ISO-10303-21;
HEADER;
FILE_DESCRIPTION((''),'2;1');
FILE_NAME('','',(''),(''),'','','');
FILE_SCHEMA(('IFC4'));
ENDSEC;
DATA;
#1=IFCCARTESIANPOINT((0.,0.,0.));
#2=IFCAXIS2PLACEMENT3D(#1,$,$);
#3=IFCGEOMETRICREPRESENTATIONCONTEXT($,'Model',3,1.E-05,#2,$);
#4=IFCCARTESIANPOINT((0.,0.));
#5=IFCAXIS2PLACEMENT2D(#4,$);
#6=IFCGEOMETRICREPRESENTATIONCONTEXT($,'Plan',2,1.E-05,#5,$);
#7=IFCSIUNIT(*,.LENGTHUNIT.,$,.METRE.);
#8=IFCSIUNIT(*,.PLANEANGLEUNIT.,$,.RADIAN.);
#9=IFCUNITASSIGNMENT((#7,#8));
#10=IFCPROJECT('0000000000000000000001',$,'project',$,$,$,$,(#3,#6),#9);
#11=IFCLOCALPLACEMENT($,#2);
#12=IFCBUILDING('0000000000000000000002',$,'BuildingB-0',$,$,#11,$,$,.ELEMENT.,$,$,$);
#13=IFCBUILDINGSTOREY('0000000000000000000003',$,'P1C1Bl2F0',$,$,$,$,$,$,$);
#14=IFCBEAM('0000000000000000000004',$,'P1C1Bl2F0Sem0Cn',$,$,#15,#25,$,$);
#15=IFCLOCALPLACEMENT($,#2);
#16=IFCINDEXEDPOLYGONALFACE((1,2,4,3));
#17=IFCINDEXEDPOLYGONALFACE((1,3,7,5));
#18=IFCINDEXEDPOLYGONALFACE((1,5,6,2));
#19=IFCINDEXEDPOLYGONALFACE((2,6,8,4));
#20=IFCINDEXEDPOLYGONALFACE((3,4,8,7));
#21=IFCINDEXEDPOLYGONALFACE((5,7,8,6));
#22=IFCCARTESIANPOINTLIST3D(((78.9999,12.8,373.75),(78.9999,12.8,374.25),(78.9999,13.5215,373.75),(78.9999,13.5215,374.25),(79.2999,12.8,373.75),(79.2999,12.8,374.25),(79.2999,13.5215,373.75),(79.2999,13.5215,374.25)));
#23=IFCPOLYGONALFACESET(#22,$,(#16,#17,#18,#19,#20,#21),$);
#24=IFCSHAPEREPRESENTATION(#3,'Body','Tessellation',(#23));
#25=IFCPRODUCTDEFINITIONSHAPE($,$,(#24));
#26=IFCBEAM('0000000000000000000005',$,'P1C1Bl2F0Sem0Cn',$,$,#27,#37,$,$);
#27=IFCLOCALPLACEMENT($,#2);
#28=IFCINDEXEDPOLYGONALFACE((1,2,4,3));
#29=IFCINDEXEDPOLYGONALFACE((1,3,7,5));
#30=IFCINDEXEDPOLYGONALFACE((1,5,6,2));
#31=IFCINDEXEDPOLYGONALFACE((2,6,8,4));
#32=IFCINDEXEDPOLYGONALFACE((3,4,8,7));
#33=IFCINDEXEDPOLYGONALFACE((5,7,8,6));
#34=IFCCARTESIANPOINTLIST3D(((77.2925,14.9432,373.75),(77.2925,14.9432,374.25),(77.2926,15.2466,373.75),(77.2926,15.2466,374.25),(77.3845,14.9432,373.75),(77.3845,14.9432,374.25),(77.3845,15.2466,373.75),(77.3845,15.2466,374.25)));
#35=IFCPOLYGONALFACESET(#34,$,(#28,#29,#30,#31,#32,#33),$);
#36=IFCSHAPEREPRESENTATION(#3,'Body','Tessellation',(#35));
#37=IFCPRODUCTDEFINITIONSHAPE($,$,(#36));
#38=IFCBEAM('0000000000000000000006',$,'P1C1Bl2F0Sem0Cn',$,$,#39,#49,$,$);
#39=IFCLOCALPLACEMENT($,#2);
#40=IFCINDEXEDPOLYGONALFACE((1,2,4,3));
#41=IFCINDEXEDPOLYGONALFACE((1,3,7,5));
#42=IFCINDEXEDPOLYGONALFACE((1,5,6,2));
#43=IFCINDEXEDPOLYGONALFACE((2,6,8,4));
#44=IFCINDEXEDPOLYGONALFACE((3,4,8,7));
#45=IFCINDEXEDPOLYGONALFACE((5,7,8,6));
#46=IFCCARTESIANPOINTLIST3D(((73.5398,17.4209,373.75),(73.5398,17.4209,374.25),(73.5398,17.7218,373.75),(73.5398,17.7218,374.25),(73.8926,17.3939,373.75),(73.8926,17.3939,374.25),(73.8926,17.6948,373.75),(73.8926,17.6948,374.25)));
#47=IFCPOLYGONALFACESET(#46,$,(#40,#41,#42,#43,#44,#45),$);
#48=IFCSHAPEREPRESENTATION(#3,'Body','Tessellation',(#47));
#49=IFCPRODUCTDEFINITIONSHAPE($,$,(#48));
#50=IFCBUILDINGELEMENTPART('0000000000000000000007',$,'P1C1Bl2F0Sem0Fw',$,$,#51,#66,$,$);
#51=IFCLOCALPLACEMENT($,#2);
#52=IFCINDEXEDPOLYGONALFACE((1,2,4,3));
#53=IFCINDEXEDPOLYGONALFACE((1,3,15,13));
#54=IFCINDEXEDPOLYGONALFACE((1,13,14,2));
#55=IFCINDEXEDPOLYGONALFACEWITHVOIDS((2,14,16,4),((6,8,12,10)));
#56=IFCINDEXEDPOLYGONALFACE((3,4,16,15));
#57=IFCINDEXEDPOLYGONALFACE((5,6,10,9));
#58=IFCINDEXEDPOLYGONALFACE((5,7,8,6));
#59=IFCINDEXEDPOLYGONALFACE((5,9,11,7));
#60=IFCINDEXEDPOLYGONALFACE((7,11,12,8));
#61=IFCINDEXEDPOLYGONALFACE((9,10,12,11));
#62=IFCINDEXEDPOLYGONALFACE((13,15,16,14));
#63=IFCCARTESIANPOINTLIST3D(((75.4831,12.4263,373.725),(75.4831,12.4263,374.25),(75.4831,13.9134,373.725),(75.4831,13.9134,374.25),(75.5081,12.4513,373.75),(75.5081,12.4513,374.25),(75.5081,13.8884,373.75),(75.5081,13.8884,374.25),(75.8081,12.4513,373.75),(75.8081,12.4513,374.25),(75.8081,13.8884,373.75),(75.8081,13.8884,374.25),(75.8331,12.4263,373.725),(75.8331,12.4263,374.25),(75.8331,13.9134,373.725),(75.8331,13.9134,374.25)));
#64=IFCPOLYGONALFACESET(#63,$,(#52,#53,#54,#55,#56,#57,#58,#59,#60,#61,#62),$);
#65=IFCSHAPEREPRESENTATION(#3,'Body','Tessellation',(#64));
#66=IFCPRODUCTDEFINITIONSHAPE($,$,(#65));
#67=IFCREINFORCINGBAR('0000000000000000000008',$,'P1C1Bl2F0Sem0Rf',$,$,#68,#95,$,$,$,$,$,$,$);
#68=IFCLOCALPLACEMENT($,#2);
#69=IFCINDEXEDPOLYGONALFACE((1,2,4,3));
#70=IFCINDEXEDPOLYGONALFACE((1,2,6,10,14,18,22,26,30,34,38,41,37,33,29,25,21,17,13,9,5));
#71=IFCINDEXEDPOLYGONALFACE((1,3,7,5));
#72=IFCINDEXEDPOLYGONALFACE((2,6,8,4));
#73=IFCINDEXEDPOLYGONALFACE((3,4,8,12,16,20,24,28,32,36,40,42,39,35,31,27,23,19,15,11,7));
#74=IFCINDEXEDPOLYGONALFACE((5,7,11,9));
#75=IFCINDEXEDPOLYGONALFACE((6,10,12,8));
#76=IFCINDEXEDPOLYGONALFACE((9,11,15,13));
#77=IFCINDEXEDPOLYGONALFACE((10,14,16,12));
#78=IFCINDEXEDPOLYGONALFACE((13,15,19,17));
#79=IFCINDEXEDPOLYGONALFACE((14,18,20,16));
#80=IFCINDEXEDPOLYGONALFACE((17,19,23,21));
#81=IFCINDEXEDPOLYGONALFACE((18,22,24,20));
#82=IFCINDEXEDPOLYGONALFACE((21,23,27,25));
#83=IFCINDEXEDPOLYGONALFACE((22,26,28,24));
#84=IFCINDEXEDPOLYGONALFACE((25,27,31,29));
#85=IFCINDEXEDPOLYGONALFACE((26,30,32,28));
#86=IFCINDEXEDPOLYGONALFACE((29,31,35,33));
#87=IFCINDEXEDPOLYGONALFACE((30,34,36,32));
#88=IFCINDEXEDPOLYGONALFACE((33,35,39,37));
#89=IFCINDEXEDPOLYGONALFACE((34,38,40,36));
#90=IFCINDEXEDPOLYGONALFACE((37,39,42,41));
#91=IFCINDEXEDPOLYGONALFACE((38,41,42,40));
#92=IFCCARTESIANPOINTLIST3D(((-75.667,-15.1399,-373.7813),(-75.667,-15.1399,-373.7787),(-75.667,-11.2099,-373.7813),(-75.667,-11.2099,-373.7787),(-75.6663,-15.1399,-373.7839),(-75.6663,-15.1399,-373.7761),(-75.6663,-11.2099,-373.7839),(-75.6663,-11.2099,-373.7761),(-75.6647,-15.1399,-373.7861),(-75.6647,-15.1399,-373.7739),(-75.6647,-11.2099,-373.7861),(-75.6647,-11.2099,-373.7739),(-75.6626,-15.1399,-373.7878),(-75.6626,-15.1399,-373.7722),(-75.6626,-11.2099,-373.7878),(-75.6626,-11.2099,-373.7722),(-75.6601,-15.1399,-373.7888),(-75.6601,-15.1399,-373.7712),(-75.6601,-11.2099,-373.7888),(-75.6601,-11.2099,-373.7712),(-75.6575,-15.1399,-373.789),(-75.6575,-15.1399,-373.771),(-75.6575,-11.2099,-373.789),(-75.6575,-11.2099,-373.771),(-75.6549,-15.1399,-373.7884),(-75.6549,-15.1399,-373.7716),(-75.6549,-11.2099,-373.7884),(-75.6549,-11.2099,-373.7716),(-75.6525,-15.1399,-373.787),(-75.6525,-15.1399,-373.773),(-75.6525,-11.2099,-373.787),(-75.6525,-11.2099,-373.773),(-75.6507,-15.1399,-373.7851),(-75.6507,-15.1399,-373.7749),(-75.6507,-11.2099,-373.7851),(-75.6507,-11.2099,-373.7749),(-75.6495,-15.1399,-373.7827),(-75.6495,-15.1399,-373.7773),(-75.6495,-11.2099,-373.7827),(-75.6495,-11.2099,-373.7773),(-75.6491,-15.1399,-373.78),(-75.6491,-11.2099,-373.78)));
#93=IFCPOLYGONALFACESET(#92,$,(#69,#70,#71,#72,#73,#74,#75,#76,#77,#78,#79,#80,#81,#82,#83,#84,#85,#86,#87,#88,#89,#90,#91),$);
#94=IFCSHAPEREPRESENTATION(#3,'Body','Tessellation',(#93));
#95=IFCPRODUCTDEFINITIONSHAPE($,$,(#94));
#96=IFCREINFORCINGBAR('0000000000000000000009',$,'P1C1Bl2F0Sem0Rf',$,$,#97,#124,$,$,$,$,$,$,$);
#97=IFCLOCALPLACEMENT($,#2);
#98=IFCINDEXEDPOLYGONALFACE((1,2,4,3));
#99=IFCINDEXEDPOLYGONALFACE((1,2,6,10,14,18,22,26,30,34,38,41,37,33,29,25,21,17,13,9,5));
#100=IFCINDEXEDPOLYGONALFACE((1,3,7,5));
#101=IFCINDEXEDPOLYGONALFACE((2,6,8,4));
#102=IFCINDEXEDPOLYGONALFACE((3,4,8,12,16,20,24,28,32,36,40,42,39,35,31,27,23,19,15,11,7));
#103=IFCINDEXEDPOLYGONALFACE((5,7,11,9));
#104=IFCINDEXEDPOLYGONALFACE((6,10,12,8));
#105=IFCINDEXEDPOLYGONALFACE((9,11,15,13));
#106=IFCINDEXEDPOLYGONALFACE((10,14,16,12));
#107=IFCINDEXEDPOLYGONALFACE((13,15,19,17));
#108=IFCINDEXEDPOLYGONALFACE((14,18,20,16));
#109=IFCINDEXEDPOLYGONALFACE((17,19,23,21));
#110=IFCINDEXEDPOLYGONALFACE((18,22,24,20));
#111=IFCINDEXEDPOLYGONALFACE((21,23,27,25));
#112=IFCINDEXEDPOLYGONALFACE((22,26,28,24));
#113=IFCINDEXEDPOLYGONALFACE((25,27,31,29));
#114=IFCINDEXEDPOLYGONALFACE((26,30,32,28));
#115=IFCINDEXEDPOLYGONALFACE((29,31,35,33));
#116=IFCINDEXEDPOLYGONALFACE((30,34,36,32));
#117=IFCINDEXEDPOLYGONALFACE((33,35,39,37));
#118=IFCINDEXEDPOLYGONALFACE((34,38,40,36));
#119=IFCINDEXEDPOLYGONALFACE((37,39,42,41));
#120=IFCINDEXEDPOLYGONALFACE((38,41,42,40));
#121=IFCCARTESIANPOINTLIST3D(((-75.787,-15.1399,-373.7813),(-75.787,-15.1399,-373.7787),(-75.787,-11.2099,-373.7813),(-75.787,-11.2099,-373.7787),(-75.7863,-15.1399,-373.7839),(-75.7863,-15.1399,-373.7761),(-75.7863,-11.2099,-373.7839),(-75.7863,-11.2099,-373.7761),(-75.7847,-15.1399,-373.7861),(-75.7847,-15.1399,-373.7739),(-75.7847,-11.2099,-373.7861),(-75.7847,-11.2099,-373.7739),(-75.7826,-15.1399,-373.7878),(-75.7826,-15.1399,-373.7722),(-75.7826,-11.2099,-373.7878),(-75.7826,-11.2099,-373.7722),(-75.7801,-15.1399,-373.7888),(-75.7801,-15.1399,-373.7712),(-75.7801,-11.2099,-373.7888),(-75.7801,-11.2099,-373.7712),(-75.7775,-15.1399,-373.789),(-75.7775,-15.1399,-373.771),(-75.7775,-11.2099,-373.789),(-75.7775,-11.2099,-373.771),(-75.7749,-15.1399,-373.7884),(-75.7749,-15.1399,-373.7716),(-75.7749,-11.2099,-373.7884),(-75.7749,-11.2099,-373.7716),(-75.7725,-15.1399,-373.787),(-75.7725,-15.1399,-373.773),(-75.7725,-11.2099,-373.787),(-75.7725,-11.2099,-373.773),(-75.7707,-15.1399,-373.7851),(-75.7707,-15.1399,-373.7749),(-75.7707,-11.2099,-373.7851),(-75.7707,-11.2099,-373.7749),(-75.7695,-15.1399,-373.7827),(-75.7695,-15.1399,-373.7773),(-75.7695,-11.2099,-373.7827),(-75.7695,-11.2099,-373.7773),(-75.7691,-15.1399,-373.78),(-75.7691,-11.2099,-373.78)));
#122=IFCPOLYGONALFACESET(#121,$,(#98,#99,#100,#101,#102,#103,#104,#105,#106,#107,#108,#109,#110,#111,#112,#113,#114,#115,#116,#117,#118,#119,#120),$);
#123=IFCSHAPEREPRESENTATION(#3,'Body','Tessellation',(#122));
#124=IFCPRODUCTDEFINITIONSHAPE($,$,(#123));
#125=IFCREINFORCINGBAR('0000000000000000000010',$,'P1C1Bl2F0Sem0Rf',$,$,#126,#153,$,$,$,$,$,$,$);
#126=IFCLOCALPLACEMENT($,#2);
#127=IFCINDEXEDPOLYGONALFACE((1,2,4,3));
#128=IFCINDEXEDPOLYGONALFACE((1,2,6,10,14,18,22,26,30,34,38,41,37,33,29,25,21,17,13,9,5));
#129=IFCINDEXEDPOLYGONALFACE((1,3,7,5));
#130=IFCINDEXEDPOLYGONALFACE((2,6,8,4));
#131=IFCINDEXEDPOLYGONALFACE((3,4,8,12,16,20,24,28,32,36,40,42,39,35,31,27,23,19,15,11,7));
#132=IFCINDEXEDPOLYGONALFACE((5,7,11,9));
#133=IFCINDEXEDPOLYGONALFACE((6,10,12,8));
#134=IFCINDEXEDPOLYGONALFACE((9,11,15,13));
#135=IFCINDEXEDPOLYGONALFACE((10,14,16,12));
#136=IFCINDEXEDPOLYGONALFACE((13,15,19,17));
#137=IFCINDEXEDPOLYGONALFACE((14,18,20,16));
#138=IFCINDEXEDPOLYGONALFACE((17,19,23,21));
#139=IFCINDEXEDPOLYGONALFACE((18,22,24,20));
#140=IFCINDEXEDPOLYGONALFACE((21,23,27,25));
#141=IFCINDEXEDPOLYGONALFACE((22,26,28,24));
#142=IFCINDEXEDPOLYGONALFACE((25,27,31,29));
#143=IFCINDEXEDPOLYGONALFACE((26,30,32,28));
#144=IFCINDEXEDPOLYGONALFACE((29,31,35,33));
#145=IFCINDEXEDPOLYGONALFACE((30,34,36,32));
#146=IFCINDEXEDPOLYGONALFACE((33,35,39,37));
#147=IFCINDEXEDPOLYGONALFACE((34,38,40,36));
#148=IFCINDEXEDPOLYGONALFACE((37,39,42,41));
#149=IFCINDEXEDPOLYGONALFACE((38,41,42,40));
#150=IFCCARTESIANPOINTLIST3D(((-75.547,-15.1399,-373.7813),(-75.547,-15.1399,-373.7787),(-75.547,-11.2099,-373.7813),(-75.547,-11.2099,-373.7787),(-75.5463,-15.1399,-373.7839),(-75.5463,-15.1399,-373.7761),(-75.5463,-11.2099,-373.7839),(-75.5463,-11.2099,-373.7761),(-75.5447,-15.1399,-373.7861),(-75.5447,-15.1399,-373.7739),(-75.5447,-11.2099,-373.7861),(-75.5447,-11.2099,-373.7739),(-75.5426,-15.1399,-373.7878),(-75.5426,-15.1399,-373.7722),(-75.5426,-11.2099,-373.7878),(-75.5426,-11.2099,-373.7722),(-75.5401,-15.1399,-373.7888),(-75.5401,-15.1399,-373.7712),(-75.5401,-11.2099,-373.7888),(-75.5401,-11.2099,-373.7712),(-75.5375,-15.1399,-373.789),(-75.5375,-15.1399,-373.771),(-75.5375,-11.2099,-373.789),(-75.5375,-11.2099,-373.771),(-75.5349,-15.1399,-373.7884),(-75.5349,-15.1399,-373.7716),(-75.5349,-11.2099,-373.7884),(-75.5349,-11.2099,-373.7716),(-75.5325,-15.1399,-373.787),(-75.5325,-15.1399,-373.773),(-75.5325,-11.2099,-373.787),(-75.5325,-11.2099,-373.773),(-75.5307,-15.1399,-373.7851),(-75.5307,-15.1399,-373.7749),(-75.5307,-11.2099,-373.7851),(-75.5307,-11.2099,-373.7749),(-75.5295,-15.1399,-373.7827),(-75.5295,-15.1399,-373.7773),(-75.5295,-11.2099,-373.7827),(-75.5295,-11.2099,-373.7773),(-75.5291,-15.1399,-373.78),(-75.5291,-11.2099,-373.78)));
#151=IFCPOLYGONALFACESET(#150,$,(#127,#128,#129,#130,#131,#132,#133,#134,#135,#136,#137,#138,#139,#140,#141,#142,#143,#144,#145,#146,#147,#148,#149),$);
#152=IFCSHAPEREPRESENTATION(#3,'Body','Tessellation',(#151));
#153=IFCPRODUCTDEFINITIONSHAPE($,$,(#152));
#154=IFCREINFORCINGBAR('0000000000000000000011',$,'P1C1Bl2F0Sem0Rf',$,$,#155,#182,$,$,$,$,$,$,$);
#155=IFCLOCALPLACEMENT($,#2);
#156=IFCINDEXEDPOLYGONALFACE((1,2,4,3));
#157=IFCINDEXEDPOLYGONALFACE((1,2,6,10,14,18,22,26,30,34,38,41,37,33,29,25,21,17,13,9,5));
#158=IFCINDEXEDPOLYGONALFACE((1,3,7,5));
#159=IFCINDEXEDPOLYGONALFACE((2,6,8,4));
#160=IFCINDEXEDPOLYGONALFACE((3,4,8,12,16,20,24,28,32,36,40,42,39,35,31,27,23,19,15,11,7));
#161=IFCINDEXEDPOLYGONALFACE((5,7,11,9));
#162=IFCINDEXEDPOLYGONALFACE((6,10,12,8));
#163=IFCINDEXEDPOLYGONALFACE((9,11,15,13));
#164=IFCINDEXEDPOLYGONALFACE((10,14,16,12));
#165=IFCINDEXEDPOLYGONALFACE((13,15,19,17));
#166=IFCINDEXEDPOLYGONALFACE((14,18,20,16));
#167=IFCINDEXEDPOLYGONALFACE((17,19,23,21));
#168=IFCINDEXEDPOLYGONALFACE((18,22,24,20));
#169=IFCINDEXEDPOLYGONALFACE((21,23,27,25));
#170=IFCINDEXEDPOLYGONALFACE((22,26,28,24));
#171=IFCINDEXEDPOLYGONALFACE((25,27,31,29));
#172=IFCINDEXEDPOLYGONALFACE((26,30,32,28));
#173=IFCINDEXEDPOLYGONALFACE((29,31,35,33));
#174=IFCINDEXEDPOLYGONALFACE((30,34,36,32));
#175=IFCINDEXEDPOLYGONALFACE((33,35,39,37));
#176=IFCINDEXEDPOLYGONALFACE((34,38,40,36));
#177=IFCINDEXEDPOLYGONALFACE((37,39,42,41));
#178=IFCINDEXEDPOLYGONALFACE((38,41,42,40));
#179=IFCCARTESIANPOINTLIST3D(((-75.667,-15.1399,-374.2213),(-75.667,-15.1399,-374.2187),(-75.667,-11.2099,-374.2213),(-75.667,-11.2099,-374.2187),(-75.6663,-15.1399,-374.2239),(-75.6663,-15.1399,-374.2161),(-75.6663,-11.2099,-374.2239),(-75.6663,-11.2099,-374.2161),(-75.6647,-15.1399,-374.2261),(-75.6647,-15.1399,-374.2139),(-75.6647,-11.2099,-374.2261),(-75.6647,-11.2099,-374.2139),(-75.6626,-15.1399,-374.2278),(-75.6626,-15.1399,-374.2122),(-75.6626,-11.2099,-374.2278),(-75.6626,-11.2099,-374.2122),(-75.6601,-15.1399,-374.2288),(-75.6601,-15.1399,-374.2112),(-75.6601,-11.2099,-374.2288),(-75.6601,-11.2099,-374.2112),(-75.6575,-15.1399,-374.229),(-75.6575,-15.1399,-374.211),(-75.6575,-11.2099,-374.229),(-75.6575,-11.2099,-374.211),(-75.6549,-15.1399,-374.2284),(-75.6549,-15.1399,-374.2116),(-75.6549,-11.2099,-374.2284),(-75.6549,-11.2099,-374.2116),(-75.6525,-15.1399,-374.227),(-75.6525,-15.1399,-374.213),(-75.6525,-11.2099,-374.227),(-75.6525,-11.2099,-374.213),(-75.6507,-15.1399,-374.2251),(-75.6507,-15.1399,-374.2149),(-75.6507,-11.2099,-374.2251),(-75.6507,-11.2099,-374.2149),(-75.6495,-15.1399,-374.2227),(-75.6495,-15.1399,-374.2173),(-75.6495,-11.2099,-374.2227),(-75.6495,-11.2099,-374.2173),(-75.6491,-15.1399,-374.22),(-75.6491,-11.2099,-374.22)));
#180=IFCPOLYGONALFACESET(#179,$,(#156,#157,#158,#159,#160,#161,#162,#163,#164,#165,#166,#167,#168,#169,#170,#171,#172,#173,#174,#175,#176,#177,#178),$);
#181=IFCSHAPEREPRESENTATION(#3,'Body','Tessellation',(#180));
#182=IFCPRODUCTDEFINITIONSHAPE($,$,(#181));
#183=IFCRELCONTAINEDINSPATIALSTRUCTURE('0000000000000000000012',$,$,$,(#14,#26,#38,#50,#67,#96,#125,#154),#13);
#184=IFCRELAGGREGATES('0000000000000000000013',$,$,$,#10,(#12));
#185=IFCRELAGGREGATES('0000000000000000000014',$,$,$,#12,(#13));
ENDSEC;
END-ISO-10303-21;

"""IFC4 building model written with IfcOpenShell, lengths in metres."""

from ifc_helpers import new_model, entity, si_unit, origin, origin_2d, place, context, project, spatial, polyline, outline, extrude, element, save


model = new_model("IFC4")

# Units and contexts
model_context = context("Model", 3, precision=1e-05, world=origin())
plan_context = context("Plan", 2, precision=1e-05, world=origin_2d())
ifc_project = project(units=[si_unit("LENGTHUNIT", "METRE"), si_unit("PLANEANGLEUNIT", "RADIAN")], contexts=[model_context, plan_context])

# Building, storey
building_placement = place(None, origin())
building = spatial("IfcBuilding", under=ifc_project, at=building_placement, Name="BuildingB-0", CompositionType="ELEMENT")
storey = spatial("IfcBuildingStorey", under=building, Name="P1C1Bl2F0")

# Beams
element("IfcBeam", 1, inside=storey, Name="P1C1Bl2F0Sem0Cn", context=model_context, shape_type="SweptSolid", body=[
    extrude(outline(polyline([(79.2999, 12.8, 373.75), (78.9999, 12.8, 373.75), (78.9999, 13.5215, 373.75), (79.2999, 13.5215, 373.75), (79.2999, 12.8, 373.75)])), None, (0.0, 0.0, 1.0), 0.5),
])
element("IfcBeam", 2, inside=storey, Name="P1C1Bl2F0Sem0Cn", context=model_context, shape_type="SweptSolid", body=[
    extrude(outline(polyline([(77.3845, 14.9432, 373.75), (77.2925, 14.9432, 373.75), (77.2926, 15.2466, 373.75), (77.3845, 15.2466, 373.75), (77.3845, 14.9432, 373.75)])), None, (0.0, 0.0, 1.0), 0.5),
])
element("IfcBeam", 3, inside=storey, Name="P1C1Bl2F0Sem0Cn", context=model_context, shape_type="SweptSolid", body=[
    extrude(outline(polyline([(73.8926, 17.3939, 373.75), (73.5398, 17.4209, 373.75), (73.5398, 17.7218, 373.75), (73.8926, 17.6948, 373.75), (73.8926, 17.3939, 373.75)])), None, (0.0, 0.0, 1.0), 0.5),
])

# Building element part, opening
building_element_part_1 = element("IfcBuildingElementPart", 4, inside=storey, Name="P1C1Bl2F0Sem0Fw", context=model_context, shape_type="SweptSolid", body=[
    extrude(outline(polyline([(75.8331, 12.4263, 373.725), (75.4831, 12.4263, 373.725), (75.4831, 13.9134, 373.725), (75.8331, 13.9134, 373.725), (75.8331, 12.4263, 373.725)])), None, (0.0, 0.0, 1.0), 0.525),
])
element("IfcOpeningElement", 5, inside=storey, cuts=building_element_part_1, context=model_context, shape_type="SweptSolid", body=[
    extrude(outline(polyline([(75.8081, 12.4513, 373.75), (75.5081, 12.4513, 373.75), (75.5081, 13.8884, 373.75), (75.8081, 13.8884, 373.75), (75.8081, 12.4513, 373.75)])), None, (0.0, 0.0, 1.0), 0.5),
])

# Reinforcing bars
element("IfcReinforcingBar", 6, inside=storey, Name="P1C1Bl2F0Sem0Rf", context=model_context, shape_type="SweptSolid", body=[
    entity("IfcSurfaceCurveSweptAreaSolid", entity("IfcCircleProfileDef", "AREA", None, None, 0.009), None, entity("IfcPolyline", [entity("IfcCartesianPoint", [75.6581, 11.2099, 373.78]), entity("IfcCartesianPoint", [75.6581, 15.1399, 373.78])]), None, None, entity("IfcPlane", entity("IfcAxis2Placement3D", entity("IfcCartesianPoint", [75.6581, 11.2099, 373.78]), entity("IfcDirection", [0.0, 0.0, 1.0]), entity("IfcDirection", [1.0, 0.0, 0.0])))),
])
element("IfcReinforcingBar", 7, inside=storey, Name="P1C1Bl2F0Sem0Rf", context=model_context, shape_type="SweptSolid", body=[
    entity("IfcSurfaceCurveSweptAreaSolid", entity("IfcCircleProfileDef", "AREA", None, None, 0.009), None, entity("IfcPolyline", [entity("IfcCartesianPoint", [75.7781, 11.2099, 373.78]), entity("IfcCartesianPoint", [75.7781, 15.1399, 373.78])]), None, None, entity("IfcPlane", entity("IfcAxis2Placement3D", entity("IfcCartesianPoint", [75.7781, 11.2099, 373.78]), entity("IfcDirection", [0.0, 0.0, 1.0]), entity("IfcDirection", [1.0, 0.0, 0.0])))),
])
element("IfcReinforcingBar", 8, inside=storey, Name="P1C1Bl2F0Sem0Rf", context=model_context, shape_type="SweptSolid", body=[
    entity("IfcSurfaceCurveSweptAreaSolid", entity("IfcCircleProfileDef", "AREA", None, None, 0.009), None, entity("IfcPolyline", [entity("IfcCartesianPoint", [75.5381, 11.2099, 373.78]), entity("IfcCartesianPoint", [75.5381, 15.1399, 373.78])]), None, None, entity("IfcPlane", entity("IfcAxis2Placement3D", entity("IfcCartesianPoint", [75.5381, 11.2099, 373.78]), entity("IfcDirection", [0.0, 0.0, 1.0]), entity("IfcDirection", [1.0, 0.0, 0.0])))),
])
element("IfcReinforcingBar", 9, inside=storey, Name="P1C1Bl2F0Sem0Rf", context=model_context, shape_type="SweptSolid", body=[
    entity("IfcSurfaceCurveSweptAreaSolid", entity("IfcCircleProfileDef", "AREA", None, None, 0.009), None, entity("IfcPolyline", [entity("IfcCartesianPoint", [75.6581, 11.2099, 374.22]), entity("IfcCartesianPoint", [75.6581, 15.1399, 374.22])]), None, None, entity("IfcPlane", entity("IfcAxis2Placement3D", entity("IfcCartesianPoint", [75.6581, 11.2099, 374.22]), entity("IfcDirection", [0.0, 0.0, 1.0]), entity("IfcDirection", [1.0, 0.0, 0.0])))),
])

save(model, "model.ifc")
